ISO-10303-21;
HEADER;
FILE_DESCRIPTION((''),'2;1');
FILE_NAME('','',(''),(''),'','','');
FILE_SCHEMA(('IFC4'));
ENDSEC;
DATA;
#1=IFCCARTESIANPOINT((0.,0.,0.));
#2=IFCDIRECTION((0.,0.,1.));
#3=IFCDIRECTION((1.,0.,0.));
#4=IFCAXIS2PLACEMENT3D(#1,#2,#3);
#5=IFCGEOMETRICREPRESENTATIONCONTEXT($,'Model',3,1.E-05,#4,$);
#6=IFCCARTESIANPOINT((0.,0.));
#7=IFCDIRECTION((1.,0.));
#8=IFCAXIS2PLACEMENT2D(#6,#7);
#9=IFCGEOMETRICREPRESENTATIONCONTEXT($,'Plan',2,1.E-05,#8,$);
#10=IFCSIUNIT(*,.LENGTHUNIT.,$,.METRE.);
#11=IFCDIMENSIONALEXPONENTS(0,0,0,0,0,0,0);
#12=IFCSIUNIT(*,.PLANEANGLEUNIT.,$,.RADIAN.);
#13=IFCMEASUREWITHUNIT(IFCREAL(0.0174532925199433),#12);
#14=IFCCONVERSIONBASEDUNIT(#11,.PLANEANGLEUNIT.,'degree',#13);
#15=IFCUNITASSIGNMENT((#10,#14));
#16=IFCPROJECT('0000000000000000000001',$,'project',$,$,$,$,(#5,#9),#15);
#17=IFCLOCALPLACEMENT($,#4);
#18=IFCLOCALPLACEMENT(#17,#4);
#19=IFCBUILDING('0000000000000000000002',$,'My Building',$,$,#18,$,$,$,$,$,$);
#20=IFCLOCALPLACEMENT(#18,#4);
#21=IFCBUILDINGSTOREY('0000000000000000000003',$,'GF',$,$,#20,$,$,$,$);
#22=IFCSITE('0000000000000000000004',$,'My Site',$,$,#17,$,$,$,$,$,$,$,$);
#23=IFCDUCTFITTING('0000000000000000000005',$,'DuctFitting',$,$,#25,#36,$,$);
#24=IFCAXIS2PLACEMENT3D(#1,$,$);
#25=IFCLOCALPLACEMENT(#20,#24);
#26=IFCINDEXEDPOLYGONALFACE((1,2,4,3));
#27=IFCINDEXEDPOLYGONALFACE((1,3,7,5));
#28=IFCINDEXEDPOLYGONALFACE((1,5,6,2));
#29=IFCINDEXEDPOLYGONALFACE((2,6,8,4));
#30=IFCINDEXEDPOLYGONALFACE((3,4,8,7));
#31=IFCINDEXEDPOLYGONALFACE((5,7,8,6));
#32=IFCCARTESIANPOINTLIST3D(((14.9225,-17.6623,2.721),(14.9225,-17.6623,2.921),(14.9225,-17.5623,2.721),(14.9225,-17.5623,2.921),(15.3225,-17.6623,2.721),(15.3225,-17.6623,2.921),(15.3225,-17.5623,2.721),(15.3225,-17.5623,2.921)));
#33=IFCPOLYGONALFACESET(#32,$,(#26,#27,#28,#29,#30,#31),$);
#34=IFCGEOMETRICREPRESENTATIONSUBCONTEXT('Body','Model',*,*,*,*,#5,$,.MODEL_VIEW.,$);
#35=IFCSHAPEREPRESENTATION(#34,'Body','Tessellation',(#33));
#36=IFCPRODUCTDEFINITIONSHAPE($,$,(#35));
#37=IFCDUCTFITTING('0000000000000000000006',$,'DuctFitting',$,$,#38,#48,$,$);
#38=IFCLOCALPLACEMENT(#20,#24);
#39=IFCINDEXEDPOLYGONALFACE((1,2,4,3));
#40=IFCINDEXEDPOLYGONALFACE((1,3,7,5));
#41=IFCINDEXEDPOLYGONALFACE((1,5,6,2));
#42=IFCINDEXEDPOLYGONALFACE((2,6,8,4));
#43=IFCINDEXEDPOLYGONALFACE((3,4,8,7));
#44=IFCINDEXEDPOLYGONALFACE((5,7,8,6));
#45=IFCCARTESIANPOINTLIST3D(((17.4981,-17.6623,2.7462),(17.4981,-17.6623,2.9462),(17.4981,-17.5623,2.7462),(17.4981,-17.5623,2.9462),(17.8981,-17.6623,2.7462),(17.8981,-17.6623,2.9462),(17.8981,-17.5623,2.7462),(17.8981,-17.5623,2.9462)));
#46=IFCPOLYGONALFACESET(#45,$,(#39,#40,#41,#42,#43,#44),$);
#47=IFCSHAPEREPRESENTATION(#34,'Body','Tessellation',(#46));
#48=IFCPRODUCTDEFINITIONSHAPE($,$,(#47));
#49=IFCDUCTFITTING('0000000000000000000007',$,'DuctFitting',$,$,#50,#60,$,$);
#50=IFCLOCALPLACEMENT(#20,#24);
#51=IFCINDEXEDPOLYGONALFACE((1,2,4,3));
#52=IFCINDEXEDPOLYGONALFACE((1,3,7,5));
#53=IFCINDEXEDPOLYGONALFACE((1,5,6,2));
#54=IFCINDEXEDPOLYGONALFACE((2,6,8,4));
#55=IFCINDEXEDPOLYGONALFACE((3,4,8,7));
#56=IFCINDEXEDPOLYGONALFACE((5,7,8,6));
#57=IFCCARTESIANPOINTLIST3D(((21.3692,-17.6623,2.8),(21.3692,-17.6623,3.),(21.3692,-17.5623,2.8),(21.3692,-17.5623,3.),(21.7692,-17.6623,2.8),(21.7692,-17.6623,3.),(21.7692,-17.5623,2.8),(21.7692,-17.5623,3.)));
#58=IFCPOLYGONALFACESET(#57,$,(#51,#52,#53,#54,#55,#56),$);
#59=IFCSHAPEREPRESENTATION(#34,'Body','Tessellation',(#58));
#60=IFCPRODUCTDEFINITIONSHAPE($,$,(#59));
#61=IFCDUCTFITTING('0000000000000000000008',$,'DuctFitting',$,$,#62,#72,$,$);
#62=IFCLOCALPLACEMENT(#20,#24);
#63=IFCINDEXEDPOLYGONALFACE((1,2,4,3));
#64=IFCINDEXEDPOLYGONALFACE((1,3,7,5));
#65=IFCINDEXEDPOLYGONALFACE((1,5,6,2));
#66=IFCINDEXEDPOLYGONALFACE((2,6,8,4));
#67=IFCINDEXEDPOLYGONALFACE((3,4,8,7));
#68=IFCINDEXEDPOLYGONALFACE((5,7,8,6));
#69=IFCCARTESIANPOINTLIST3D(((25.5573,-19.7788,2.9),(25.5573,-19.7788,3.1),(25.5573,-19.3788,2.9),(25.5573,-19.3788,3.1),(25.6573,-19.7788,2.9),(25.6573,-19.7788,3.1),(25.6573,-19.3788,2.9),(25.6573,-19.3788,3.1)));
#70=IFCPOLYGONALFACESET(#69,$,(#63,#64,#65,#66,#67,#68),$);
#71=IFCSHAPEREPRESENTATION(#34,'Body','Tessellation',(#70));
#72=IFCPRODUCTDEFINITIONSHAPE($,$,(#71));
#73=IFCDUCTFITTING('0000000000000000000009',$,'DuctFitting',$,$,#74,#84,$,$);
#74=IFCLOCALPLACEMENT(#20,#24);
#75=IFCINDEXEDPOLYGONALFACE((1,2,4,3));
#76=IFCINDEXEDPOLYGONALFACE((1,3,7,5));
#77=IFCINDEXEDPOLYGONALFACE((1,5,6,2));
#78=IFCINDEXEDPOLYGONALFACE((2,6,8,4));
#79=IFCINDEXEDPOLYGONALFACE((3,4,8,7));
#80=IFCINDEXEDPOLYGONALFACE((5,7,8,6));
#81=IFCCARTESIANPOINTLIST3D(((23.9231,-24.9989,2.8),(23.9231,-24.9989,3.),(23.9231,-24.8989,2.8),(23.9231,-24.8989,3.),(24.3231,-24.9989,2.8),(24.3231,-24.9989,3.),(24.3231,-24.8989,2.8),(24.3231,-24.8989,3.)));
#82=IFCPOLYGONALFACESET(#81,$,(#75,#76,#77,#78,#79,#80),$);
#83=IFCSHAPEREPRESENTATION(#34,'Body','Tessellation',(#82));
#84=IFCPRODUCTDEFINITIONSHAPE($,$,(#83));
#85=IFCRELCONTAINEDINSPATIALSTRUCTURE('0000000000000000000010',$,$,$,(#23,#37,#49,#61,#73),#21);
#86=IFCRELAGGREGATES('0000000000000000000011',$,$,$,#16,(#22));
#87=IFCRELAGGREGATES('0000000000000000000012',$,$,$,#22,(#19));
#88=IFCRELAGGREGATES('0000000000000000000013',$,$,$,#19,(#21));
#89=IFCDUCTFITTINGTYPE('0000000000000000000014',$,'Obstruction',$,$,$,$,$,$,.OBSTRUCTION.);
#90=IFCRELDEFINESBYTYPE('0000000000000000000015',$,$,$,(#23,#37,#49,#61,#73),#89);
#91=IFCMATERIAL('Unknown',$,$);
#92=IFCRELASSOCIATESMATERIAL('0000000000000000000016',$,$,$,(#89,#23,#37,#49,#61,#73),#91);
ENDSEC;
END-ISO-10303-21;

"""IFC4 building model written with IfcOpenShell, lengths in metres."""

from ifc_helpers import new_model, entity, si_unit, converted_unit, frame, origin_with_axes, origin_2d_with_axis, place, context, subcontext, project, spatial, rectangle, extrude, material, material_profile, profile_set, profile_usage, type_object, element, save


model = new_model("IFC4")

# Units and contexts
model_context = context("Model", 3, precision=1e-05, world=origin_with_axes())
plan_context = context("Plan", 2, precision=1e-05, world=origin_2d_with_axis())
body_context_1 = subcontext(model_context, "Body", "Model", "MODEL_VIEW")
ifc_project = project(units=[si_unit("LENGTHUNIT", "METRE"), converted_unit("PLANEANGLEUNIT", "degree", entity("IfcReal", 0.0174532925199433), si_unit("PLANEANGLEUNIT", "RADIAN"), dimensions=[0, 0, 0, 0, 0, 0, 0])], contexts=[model_context, plan_context])

# Site, building, storey
site_placement = place(None, origin_with_axes())
site = spatial("IfcSite", under=ifc_project, at=site_placement, Name="My Site")
building_placement = place(site_placement, origin_with_axes())
building = spatial("IfcBuilding", under=site, at=building_placement, Name="My Building")
storey_placement = place(building_placement, origin_with_axes())
storey = spatial("IfcBuildingStorey", under=building, at=storey_placement, Name="GF")

# Shared definitions
ifc_material = material(Name="Unknown")

# Duct fittings
ifc_material_profile_1 = material_profile(ifc_material, rectangle(XDim=0.4, YDim=0.2))
ifc_profile_set_1 = profile_set([ifc_material_profile_1])
duct_fitting_type = type_object("IfcDuctFittingType", Name="Obstruction", PredefinedType="OBSTRUCTION", material=ifc_profile_set_1)
ifc_profile_usage_1 = profile_usage(ifc_profile_set_1, cardinal=5)
duct_fitting_1_placement = place(storey_placement, frame((15.1225, -17.5623, 2.821), z_axis=(0.0, -1.0, 0.0), x_axis=(1.0, 0.0, 0.0)))
element("IfcDuctFitting", 1, at=duct_fitting_1_placement, inside=storey, type_object=duct_fitting_type, material=ifc_profile_usage_1, Name="DuctFitting", context=body_context_1, shape_type="SweptSolid", body=[
    extrude(rectangle(XDim=0.4, YDim=0.2), origin_with_axes(), (0.0, 0.0, 1.0), 0.1),
])
ifc_profile_usage_2 = profile_usage(ifc_profile_set_1, cardinal=5)
duct_fitting_2_placement = place(storey_placement, frame((17.6981, -17.5623, 2.8462), z_axis=(0.0, -1.0, 0.0), x_axis=(1.0, 0.0, 0.0)))
element("IfcDuctFitting", 2, at=duct_fitting_2_placement, inside=storey, type_object=duct_fitting_type, material=ifc_profile_usage_2, Name="DuctFitting", context=body_context_1, shape_type="SweptSolid", body=[
    extrude(rectangle(XDim=0.4, YDim=0.2), origin_with_axes(), (0.0, 0.0, 1.0), 0.1),
])
ifc_profile_usage_3 = profile_usage(ifc_profile_set_1, cardinal=5)
duct_fitting_3_placement = place(storey_placement, frame((21.5692, -17.5623, 2.9), z_axis=(0.0, -1.0, 0.0), x_axis=(1.0, 0.0, 0.0)))
element("IfcDuctFitting", 3, at=duct_fitting_3_placement, inside=storey, type_object=duct_fitting_type, material=ifc_profile_usage_3, Name="DuctFitting", context=body_context_1, shape_type="SweptSolid", body=[
    extrude(rectangle(XDim=0.4, YDim=0.2), origin_with_axes(), (0.0, 0.0, 1.0), 0.1),
])
ifc_profile_usage_4 = profile_usage(ifc_profile_set_1, cardinal=5)
duct_fitting_4_placement = place(storey_placement, frame((25.5573, -19.5788, 3.0), z_axis=(1.0, 0.0, 0.0), x_axis=(0.0, 1.0, 0.0)))
element("IfcDuctFitting", 4, at=duct_fitting_4_placement, inside=storey, type_object=duct_fitting_type, material=ifc_profile_usage_4, Name="DuctFitting", context=body_context_1, shape_type="SweptSolid", body=[
    extrude(rectangle(XDim=0.4, YDim=0.2), origin_with_axes(), (0.0, 0.0, 1.0), 0.1),
])
ifc_profile_usage_5 = profile_usage(ifc_profile_set_1, cardinal=5)
duct_fitting_5_placement = place(storey_placement, frame((24.1231, -24.8989, 2.9), z_axis=(0.0, -1.0, 0.0), x_axis=(1.0, 0.0, 0.0)))
element("IfcDuctFitting", 5, at=duct_fitting_5_placement, inside=storey, type_object=duct_fitting_type, material=ifc_profile_usage_5, Name="DuctFitting", context=body_context_1, shape_type="SweptSolid", body=[
    extrude(rectangle(XDim=0.4, YDim=0.2), origin_with_axes(), (0.0, 0.0, 1.0), 0.1),
])

save(model, "model.ifc")
